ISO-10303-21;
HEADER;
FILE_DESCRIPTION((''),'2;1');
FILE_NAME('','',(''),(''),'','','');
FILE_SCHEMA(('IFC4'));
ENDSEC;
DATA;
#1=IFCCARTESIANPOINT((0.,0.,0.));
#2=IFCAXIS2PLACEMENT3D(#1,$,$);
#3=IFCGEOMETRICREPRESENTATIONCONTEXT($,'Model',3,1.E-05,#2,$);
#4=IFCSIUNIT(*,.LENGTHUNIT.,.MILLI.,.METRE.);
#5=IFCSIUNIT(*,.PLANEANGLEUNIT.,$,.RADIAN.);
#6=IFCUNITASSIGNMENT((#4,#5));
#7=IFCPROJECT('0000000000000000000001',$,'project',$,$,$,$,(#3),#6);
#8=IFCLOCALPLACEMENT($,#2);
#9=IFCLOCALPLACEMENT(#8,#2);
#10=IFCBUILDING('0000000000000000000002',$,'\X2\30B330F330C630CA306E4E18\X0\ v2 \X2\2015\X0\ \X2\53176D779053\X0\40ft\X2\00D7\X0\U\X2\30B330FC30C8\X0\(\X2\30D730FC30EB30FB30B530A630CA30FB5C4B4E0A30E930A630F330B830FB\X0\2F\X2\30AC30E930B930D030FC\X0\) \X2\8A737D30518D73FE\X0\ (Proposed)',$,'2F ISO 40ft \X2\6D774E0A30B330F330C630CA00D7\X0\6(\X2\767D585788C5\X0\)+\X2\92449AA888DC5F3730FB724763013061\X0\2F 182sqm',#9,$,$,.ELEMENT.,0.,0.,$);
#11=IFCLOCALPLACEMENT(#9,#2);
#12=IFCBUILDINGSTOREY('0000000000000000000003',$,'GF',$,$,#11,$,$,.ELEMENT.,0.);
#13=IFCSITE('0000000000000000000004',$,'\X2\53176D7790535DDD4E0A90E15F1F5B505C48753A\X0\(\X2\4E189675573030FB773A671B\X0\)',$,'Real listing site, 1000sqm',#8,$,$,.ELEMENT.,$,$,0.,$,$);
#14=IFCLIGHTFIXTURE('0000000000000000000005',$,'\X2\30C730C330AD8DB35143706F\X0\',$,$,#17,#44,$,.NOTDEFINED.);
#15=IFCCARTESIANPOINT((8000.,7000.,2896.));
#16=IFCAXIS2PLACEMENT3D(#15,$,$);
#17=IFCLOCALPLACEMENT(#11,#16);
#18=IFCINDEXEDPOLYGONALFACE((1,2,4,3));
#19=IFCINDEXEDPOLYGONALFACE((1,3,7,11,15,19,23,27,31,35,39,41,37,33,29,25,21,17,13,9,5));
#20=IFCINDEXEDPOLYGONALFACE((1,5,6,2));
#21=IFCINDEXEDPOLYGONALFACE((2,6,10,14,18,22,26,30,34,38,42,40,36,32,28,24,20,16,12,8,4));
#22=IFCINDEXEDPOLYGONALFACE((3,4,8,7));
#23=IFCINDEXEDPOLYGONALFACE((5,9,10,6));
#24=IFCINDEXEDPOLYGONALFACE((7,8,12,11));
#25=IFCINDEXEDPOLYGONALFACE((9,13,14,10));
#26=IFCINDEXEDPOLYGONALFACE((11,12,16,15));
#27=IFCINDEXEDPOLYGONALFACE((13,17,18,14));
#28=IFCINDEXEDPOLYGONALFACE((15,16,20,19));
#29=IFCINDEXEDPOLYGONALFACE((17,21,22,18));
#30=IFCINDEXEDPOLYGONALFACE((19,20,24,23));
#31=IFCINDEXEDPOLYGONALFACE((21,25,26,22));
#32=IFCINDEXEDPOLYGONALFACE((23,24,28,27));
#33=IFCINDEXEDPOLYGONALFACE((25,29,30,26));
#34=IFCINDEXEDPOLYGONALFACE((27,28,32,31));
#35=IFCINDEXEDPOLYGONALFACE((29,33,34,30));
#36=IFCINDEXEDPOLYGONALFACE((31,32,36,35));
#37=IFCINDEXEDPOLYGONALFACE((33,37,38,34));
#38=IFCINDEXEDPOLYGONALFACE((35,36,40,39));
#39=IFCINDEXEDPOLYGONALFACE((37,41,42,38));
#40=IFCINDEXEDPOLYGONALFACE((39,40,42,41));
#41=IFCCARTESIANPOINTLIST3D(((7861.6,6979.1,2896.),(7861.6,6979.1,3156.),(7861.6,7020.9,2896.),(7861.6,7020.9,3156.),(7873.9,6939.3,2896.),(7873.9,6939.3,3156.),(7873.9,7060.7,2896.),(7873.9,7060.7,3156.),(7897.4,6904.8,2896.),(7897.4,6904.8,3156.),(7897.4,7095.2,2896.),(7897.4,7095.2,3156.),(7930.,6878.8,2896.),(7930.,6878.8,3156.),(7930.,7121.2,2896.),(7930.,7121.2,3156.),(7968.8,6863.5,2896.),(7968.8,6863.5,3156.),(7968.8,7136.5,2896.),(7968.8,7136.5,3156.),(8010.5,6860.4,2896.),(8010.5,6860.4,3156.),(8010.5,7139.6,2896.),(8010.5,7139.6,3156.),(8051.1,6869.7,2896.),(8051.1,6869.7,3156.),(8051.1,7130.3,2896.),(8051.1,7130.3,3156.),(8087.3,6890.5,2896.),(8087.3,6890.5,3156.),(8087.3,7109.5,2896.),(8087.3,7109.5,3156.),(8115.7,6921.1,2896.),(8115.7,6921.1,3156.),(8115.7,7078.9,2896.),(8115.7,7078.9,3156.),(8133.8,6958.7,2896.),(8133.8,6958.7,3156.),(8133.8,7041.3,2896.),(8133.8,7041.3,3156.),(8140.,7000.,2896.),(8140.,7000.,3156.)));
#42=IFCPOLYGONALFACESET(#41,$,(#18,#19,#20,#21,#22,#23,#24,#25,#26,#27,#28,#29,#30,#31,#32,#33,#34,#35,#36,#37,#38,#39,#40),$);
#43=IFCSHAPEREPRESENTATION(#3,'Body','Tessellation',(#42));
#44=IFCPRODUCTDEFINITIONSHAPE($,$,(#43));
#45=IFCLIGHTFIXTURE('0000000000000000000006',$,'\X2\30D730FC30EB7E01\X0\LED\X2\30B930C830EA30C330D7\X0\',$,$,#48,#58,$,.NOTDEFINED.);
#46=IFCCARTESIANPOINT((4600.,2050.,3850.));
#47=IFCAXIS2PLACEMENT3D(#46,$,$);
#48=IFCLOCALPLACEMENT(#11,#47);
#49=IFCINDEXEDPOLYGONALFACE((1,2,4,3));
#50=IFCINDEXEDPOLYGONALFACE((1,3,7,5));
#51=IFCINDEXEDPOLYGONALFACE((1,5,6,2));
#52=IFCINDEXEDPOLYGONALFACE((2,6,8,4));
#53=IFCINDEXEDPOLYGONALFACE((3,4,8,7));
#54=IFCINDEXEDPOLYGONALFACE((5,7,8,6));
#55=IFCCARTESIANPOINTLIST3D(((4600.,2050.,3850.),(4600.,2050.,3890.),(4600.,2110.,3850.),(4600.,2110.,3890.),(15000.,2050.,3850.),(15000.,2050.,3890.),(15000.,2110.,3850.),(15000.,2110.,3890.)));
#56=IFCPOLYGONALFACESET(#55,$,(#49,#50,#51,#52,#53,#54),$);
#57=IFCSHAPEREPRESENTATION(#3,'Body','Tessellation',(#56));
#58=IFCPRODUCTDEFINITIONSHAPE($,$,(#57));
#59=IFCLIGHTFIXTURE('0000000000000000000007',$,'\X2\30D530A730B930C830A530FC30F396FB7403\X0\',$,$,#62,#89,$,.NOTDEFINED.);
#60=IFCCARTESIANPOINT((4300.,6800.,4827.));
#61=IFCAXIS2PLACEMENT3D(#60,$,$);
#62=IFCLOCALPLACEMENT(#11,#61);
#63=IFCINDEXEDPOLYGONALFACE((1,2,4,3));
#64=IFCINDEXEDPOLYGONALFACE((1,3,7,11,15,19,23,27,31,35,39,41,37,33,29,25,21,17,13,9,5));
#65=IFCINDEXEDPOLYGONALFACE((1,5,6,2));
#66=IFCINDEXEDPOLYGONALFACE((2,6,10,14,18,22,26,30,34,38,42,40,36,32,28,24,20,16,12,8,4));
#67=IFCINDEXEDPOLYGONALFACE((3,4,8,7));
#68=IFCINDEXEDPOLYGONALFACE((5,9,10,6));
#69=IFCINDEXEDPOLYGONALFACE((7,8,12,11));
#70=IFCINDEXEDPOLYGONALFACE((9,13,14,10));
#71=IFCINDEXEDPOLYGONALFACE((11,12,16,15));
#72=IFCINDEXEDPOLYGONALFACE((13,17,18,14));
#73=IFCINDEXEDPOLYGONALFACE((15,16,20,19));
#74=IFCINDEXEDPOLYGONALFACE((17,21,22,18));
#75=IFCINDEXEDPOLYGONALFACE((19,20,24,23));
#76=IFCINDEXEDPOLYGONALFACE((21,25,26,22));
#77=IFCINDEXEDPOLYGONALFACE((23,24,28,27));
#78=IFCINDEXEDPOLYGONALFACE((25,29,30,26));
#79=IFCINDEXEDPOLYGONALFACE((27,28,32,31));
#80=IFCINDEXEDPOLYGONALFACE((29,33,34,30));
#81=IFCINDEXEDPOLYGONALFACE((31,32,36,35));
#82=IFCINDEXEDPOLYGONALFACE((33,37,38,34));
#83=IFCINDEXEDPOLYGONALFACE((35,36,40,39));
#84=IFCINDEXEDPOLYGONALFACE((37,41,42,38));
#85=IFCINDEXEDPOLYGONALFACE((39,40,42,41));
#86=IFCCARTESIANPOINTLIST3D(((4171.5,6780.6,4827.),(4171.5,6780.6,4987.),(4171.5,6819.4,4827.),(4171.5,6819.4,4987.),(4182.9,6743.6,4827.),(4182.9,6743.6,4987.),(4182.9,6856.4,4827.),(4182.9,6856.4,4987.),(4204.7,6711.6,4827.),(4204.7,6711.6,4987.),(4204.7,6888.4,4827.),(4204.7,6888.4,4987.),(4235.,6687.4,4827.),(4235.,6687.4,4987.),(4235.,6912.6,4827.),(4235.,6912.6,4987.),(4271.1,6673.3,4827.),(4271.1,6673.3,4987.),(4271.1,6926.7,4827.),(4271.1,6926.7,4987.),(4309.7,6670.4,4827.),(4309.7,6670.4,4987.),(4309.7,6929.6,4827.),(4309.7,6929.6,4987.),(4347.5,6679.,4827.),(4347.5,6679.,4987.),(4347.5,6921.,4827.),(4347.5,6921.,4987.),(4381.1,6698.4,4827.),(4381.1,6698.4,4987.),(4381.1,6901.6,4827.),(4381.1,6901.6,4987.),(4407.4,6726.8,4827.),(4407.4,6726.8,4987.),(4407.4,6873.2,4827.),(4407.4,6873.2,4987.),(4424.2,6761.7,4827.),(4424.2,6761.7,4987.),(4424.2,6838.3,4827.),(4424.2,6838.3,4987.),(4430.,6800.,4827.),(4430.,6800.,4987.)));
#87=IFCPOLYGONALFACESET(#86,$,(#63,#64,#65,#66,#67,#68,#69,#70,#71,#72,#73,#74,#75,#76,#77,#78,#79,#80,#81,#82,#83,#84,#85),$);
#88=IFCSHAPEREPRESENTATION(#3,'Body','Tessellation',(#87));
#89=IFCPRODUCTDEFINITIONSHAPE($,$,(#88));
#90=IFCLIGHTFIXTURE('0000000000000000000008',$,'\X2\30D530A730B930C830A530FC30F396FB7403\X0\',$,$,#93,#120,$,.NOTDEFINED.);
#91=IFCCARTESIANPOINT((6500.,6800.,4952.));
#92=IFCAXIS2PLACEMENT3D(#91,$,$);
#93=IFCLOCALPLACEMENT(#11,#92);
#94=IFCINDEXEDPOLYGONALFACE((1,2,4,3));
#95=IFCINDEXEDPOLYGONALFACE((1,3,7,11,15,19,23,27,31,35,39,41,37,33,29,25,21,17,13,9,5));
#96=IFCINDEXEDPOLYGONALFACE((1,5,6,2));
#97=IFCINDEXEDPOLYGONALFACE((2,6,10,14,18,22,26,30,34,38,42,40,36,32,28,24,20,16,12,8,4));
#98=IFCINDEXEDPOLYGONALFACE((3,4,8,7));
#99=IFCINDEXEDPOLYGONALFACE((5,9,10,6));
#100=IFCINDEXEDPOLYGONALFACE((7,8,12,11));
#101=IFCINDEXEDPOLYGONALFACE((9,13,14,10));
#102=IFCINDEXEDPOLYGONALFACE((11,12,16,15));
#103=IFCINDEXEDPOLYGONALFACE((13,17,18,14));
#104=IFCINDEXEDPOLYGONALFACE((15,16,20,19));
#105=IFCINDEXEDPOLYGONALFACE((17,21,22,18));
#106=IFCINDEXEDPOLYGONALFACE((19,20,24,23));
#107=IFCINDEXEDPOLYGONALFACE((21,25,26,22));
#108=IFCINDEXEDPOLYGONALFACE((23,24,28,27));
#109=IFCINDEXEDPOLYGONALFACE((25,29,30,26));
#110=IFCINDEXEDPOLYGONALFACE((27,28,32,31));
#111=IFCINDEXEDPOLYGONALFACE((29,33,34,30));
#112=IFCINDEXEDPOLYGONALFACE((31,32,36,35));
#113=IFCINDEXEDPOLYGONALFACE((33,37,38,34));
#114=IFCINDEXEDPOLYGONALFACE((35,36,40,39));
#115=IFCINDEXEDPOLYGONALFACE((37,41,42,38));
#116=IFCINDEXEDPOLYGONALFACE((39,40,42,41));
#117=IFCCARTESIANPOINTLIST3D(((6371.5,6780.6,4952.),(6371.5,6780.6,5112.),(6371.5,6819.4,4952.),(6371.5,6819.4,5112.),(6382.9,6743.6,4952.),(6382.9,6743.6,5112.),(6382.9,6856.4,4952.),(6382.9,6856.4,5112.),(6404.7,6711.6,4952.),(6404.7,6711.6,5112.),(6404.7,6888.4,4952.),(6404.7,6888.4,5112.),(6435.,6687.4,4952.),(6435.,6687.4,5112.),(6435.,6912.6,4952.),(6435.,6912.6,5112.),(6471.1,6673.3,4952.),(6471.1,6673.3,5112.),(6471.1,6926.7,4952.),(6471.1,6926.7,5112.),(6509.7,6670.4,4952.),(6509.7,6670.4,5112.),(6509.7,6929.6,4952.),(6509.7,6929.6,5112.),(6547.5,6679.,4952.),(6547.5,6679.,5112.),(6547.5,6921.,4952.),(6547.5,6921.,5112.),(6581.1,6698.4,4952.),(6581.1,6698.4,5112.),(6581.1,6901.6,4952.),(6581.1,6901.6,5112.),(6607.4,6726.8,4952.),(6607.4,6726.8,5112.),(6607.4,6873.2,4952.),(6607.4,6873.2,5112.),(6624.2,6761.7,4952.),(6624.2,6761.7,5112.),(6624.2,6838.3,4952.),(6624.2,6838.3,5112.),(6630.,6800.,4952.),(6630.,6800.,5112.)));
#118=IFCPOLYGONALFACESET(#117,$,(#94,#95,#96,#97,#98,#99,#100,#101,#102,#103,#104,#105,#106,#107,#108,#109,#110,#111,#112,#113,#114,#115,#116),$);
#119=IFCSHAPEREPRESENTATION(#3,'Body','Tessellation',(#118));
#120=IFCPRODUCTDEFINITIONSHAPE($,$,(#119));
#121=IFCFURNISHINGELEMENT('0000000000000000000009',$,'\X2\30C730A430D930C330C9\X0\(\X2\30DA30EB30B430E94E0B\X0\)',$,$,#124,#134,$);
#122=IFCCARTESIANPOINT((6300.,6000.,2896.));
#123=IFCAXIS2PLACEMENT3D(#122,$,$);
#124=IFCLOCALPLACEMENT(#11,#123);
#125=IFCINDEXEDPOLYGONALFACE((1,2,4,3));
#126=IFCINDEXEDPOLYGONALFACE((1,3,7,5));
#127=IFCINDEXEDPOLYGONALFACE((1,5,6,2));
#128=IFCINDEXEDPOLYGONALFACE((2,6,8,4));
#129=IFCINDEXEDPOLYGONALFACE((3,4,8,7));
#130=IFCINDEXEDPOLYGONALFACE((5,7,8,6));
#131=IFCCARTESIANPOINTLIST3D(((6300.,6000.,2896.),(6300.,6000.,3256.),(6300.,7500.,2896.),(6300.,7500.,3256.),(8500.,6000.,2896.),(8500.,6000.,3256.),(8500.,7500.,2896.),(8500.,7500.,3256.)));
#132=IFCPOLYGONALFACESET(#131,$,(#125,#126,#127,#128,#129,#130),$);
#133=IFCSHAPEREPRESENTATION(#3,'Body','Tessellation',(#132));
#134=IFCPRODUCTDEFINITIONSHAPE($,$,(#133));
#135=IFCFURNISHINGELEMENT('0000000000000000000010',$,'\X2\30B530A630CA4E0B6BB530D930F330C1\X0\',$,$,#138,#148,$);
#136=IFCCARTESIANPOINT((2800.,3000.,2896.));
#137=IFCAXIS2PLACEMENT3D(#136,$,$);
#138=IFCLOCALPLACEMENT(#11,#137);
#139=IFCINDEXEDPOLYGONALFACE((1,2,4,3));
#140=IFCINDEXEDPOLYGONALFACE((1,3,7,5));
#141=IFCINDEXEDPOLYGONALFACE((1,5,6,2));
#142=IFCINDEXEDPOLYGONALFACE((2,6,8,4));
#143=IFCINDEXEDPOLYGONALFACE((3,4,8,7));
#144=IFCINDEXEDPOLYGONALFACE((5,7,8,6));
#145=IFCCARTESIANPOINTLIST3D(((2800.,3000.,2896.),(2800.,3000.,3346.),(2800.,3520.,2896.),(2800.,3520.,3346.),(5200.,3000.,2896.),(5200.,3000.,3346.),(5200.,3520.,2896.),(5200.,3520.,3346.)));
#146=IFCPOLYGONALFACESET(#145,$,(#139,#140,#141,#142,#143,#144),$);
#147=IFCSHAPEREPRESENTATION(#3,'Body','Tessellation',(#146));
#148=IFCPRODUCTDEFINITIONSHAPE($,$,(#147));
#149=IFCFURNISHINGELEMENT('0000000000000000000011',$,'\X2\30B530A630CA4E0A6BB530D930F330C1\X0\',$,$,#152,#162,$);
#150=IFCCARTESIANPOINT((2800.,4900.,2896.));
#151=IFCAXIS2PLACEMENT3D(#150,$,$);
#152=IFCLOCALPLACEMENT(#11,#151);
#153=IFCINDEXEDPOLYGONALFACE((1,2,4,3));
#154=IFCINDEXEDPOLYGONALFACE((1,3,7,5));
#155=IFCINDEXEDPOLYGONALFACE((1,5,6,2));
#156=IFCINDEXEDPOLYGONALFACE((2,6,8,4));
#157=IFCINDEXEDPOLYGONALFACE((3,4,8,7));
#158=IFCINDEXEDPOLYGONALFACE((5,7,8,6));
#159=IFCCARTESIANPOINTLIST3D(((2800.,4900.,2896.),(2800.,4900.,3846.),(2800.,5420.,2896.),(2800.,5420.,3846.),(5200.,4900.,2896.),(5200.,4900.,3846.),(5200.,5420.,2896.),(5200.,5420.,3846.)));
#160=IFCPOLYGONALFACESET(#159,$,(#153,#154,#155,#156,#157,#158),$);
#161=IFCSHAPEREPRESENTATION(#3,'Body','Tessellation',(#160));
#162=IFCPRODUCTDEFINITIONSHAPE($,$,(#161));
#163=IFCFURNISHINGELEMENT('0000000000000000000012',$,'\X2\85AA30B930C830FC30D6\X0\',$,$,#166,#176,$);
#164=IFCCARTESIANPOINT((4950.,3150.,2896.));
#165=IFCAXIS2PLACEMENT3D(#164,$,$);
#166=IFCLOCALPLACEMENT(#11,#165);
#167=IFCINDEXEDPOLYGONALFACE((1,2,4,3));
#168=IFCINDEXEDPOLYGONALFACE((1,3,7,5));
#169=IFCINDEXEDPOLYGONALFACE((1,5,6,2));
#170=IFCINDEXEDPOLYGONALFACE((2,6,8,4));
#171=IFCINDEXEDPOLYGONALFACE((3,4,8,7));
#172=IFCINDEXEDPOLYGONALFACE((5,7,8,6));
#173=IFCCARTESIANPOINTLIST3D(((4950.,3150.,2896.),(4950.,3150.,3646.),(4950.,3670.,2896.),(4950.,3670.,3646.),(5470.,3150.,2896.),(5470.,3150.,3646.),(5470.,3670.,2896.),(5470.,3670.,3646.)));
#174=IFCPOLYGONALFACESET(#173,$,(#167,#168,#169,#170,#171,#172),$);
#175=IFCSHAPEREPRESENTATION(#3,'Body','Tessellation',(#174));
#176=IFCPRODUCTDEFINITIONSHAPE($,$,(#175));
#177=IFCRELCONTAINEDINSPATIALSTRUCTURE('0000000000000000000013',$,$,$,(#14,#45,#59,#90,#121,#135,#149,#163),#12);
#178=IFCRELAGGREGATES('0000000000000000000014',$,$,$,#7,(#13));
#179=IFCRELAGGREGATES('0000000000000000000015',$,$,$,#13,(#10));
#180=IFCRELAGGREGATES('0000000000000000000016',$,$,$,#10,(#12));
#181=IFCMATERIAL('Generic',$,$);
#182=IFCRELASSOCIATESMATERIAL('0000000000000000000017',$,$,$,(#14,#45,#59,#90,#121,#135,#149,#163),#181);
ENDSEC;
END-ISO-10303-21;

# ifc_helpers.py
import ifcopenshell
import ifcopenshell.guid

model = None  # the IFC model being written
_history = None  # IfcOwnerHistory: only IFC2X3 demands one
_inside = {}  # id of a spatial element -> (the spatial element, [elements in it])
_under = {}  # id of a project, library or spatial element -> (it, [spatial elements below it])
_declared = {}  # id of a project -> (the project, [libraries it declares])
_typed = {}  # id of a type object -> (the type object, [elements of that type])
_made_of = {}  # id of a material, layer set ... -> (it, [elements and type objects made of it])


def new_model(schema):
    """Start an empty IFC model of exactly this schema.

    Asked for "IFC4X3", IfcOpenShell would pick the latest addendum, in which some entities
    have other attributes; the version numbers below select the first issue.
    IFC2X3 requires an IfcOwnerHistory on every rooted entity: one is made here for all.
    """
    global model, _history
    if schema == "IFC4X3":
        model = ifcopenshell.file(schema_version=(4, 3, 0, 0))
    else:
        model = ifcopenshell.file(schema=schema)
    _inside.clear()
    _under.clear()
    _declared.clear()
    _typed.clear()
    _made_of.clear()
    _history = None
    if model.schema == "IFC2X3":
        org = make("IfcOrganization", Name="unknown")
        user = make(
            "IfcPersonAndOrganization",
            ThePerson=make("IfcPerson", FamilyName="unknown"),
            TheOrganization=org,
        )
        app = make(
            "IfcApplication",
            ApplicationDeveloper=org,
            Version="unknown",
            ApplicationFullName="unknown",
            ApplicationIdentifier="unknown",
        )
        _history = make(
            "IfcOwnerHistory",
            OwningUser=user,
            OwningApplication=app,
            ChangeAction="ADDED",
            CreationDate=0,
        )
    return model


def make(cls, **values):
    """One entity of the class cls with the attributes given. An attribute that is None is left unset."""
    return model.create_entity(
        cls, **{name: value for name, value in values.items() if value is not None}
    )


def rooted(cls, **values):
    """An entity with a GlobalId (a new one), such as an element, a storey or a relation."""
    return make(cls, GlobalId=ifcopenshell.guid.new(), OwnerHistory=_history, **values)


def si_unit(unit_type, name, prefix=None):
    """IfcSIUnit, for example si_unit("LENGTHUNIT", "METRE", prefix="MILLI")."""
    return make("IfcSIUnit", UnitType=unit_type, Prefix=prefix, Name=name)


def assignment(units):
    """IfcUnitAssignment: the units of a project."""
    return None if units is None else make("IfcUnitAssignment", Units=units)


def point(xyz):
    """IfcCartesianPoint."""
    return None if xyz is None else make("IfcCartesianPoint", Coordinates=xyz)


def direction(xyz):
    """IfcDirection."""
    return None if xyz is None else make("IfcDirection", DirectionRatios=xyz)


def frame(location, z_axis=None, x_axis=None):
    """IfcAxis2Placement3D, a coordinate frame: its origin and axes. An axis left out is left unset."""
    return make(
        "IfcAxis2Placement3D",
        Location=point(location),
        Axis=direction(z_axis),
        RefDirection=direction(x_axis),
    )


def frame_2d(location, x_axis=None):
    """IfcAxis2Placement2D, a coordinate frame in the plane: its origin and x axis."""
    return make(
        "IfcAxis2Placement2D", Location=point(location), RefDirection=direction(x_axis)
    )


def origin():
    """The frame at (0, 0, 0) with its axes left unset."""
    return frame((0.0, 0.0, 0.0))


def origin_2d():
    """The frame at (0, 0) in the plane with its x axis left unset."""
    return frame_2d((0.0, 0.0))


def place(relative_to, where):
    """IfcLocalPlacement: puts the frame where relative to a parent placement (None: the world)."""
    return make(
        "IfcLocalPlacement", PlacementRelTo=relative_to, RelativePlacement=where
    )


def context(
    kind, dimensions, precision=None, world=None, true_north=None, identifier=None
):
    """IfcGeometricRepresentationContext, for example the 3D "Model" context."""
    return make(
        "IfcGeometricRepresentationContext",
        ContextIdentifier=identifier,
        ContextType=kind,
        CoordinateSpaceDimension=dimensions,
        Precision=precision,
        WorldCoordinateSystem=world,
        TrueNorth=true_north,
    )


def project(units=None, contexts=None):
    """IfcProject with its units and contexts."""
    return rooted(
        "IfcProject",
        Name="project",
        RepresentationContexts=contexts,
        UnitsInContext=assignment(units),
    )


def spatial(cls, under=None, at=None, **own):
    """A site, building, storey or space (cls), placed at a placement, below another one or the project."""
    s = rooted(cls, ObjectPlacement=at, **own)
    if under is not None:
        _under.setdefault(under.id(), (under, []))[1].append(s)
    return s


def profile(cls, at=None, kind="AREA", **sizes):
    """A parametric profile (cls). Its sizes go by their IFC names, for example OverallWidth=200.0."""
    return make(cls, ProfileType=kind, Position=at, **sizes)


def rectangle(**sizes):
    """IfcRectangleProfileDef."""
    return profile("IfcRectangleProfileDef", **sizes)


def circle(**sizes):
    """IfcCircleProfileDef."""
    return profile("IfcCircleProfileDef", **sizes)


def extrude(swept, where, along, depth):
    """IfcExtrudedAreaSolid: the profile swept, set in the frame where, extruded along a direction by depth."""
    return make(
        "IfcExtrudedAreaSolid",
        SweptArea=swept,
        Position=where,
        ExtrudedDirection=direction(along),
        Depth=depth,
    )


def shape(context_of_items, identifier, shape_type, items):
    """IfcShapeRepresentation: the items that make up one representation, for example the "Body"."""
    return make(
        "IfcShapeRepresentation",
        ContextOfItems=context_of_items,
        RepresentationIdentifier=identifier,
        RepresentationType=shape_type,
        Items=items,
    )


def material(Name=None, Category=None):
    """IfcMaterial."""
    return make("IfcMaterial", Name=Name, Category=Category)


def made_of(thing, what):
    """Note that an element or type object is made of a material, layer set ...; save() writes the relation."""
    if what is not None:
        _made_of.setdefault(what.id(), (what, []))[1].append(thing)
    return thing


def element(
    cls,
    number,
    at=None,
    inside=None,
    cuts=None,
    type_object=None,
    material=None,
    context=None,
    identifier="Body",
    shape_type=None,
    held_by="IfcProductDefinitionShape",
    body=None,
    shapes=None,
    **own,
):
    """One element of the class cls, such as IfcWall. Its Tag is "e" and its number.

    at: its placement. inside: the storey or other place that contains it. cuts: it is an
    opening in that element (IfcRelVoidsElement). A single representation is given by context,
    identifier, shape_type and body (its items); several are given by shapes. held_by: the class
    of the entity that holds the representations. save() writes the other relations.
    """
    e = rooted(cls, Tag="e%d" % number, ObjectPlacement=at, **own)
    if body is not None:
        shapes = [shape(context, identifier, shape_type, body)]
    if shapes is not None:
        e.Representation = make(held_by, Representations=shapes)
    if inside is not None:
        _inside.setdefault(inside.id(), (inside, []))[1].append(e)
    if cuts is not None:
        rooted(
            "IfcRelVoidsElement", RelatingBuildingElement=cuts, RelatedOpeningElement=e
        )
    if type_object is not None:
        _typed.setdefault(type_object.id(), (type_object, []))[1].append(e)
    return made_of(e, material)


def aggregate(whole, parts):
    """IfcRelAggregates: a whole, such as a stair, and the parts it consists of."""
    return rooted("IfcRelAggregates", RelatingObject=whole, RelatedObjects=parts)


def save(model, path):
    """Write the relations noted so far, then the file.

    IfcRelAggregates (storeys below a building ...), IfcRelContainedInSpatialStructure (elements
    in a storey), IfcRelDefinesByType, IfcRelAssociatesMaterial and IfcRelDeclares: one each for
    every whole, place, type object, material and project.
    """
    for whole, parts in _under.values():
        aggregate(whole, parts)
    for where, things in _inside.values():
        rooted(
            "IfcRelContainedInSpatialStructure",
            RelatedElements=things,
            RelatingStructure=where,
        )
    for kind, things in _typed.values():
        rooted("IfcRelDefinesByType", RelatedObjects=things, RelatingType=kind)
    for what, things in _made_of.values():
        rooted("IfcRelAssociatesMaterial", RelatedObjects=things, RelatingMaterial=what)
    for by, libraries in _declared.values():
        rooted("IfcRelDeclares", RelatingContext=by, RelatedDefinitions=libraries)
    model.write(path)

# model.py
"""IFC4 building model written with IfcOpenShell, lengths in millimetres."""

from ifc_helpers import new_model, si_unit, frame, frame_2d, origin, origin_2d, place, context, project, spatial, rectangle, circle, extrude, material, element, save


model = new_model("IFC4")

# Units and contexts
model_context = context("Model", 3, precision=1e-05, world=origin())
ifc_project = project(units=[si_unit("LENGTHUNIT", "METRE", prefix="MILLI"), si_unit("PLANEANGLEUNIT", "RADIAN")], contexts=[model_context])

# Site, building, storey
site_placement = place(None, origin())
site = spatial("IfcSite", under=ifc_project, at=site_placement, Name="北海道川上郡弟子屈町(丘陵地・眺望)", ObjectType="Real listing site, 1000sqm", CompositionType="ELEMENT", RefElevation=0.0)
building_placement = place(site_placement, origin())
building = spatial("IfcBuilding", under=site, at=building_placement, Name="コンテナの丘 v2 ― 北海道40ft×Uコート(プール・サウナ・屋上ラウンジ・2Fガラスバー) 詳細再現 (Proposed)", ObjectType="2F ISO 40ft 海上コンテナ×6(白塗装)+鉄骨補強・片持ち2F 182sqm", CompositionType="ELEMENT", ElevationOfRefHeight=0.0, ElevationOfTerrain=0.0)
storey_placement = place(building_placement, origin())
storey = spatial("IfcBuildingStorey", under=building, at=storey_placement, Name="GF", CompositionType="ELEMENT", Elevation=0.0)

# Shared definitions
ifc_material = material(Name="Generic")

# Light fixtures
light_fixture_1_placement = place(storey_placement, frame((8000.0, 7000.0, 2896.0)))
element("IfcLightFixture", 1, at=light_fixture_1_placement, inside=storey, material=ifc_material, Name="デッキ足元灯", PredefinedType="NOTDEFINED", context=model_context, shape_type="SweptSolid", body=[
    extrude(circle(Radius=140.0, at=origin_2d()), frame((8000.0, 7000.0, 2896.0)), (0.0, 0.0, 1.0), 260.0),
])
light_fixture_2_placement = place(storey_placement, frame((4600.0, 2050.0, 3850.0)))
element("IfcLightFixture", 2, at=light_fixture_2_placement, inside=storey, material=ifc_material, Name="プール縁LEDストリップ", PredefinedType="NOTDEFINED", context=model_context, shape_type="SweptSolid", body=[
    extrude(rectangle(XDim=10400.0, YDim=60.0, at=frame_2d((5200.0, 30.0))), frame((4600.0, 2050.0, 3850.0)), (0.0, 0.0, 1.0), 40.0),
])
light_fixture_3_placement = place(storey_placement, frame((4300.0, 6800.0, 4827.0)))
element("IfcLightFixture", 3, at=light_fixture_3_placement, inside=storey, material=ifc_material, Name="フェストゥーン電球", PredefinedType="NOTDEFINED", context=model_context, shape_type="SweptSolid", body=[
    extrude(circle(Radius=130.0, at=origin_2d()), frame((4300.0, 6800.0, 4827.0)), (0.0, 0.0, 1.0), 160.0),
])
light_fixture_4_placement = place(storey_placement, frame((6500.0, 6800.0, 4952.0)))
element("IfcLightFixture", 4, at=light_fixture_4_placement, inside=storey, material=ifc_material, Name="フェストゥーン電球", PredefinedType="NOTDEFINED", context=model_context, shape_type="SweptSolid", body=[
    extrude(circle(Radius=130.0, at=origin_2d()), frame((6500.0, 6800.0, 4952.0)), (0.0, 0.0, 1.0), 160.0),
])

# Furnishing elements
furnishing_1_placement = place(storey_placement, frame((6300.0, 6000.0, 2896.0)))
element("IfcFurnishingElement", 5, at=furnishing_1_placement, inside=storey, material=ifc_material, Name="デイベッド(ペルゴラ下)", context=model_context, shape_type="SweptSolid", body=[
    extrude(rectangle(XDim=2200.0, YDim=1500.0, at=frame_2d((1100.0, 750.0))), frame((6300.0, 6000.0, 2896.0)), (0.0, 0.0, 1.0), 360.0),
])
furnishing_2_placement = place(storey_placement, frame((2800.0, 3000.0, 2896.0)))
element("IfcFurnishingElement", 6, at=furnishing_2_placement, inside=storey, material=ifc_material, Name="サウナ下段ベンチ", context=model_context, shape_type="SweptSolid", body=[
    extrude(rectangle(XDim=2400.0, YDim=520.0, at=frame_2d((1200.0, 260.0))), frame((2800.0, 3000.0, 2896.0)), (0.0, 0.0, 1.0), 450.0),
])
furnishing_3_placement = place(storey_placement, frame((2800.0, 4900.0, 2896.0)))
element("IfcFurnishingElement", 7, at=furnishing_3_placement, inside=storey, material=ifc_material, Name="サウナ上段ベンチ", context=model_context, shape_type="SweptSolid", body=[
    extrude(rectangle(XDim=2400.0, YDim=520.0, at=frame_2d((1200.0, 260.0))), frame((2800.0, 4900.0, 2896.0)), (0.0, 0.0, 1.0), 950.0),
])
furnishing_4_placement = place(storey_placement, frame((4950.0, 3150.0, 2896.0)))
element("IfcFurnishingElement", 8, at=furnishing_4_placement, inside=storey, material=ifc_material, Name="薪ストーブ", context=model_context, shape_type="SweptSolid", body=[
    extrude(rectangle(XDim=520.0, YDim=520.0, at=frame_2d((260.0, 260.0))), frame((4950.0, 3150.0, 2896.0)), (0.0, 0.0, 1.0), 750.0),
])

save(model, "model.ifc")
